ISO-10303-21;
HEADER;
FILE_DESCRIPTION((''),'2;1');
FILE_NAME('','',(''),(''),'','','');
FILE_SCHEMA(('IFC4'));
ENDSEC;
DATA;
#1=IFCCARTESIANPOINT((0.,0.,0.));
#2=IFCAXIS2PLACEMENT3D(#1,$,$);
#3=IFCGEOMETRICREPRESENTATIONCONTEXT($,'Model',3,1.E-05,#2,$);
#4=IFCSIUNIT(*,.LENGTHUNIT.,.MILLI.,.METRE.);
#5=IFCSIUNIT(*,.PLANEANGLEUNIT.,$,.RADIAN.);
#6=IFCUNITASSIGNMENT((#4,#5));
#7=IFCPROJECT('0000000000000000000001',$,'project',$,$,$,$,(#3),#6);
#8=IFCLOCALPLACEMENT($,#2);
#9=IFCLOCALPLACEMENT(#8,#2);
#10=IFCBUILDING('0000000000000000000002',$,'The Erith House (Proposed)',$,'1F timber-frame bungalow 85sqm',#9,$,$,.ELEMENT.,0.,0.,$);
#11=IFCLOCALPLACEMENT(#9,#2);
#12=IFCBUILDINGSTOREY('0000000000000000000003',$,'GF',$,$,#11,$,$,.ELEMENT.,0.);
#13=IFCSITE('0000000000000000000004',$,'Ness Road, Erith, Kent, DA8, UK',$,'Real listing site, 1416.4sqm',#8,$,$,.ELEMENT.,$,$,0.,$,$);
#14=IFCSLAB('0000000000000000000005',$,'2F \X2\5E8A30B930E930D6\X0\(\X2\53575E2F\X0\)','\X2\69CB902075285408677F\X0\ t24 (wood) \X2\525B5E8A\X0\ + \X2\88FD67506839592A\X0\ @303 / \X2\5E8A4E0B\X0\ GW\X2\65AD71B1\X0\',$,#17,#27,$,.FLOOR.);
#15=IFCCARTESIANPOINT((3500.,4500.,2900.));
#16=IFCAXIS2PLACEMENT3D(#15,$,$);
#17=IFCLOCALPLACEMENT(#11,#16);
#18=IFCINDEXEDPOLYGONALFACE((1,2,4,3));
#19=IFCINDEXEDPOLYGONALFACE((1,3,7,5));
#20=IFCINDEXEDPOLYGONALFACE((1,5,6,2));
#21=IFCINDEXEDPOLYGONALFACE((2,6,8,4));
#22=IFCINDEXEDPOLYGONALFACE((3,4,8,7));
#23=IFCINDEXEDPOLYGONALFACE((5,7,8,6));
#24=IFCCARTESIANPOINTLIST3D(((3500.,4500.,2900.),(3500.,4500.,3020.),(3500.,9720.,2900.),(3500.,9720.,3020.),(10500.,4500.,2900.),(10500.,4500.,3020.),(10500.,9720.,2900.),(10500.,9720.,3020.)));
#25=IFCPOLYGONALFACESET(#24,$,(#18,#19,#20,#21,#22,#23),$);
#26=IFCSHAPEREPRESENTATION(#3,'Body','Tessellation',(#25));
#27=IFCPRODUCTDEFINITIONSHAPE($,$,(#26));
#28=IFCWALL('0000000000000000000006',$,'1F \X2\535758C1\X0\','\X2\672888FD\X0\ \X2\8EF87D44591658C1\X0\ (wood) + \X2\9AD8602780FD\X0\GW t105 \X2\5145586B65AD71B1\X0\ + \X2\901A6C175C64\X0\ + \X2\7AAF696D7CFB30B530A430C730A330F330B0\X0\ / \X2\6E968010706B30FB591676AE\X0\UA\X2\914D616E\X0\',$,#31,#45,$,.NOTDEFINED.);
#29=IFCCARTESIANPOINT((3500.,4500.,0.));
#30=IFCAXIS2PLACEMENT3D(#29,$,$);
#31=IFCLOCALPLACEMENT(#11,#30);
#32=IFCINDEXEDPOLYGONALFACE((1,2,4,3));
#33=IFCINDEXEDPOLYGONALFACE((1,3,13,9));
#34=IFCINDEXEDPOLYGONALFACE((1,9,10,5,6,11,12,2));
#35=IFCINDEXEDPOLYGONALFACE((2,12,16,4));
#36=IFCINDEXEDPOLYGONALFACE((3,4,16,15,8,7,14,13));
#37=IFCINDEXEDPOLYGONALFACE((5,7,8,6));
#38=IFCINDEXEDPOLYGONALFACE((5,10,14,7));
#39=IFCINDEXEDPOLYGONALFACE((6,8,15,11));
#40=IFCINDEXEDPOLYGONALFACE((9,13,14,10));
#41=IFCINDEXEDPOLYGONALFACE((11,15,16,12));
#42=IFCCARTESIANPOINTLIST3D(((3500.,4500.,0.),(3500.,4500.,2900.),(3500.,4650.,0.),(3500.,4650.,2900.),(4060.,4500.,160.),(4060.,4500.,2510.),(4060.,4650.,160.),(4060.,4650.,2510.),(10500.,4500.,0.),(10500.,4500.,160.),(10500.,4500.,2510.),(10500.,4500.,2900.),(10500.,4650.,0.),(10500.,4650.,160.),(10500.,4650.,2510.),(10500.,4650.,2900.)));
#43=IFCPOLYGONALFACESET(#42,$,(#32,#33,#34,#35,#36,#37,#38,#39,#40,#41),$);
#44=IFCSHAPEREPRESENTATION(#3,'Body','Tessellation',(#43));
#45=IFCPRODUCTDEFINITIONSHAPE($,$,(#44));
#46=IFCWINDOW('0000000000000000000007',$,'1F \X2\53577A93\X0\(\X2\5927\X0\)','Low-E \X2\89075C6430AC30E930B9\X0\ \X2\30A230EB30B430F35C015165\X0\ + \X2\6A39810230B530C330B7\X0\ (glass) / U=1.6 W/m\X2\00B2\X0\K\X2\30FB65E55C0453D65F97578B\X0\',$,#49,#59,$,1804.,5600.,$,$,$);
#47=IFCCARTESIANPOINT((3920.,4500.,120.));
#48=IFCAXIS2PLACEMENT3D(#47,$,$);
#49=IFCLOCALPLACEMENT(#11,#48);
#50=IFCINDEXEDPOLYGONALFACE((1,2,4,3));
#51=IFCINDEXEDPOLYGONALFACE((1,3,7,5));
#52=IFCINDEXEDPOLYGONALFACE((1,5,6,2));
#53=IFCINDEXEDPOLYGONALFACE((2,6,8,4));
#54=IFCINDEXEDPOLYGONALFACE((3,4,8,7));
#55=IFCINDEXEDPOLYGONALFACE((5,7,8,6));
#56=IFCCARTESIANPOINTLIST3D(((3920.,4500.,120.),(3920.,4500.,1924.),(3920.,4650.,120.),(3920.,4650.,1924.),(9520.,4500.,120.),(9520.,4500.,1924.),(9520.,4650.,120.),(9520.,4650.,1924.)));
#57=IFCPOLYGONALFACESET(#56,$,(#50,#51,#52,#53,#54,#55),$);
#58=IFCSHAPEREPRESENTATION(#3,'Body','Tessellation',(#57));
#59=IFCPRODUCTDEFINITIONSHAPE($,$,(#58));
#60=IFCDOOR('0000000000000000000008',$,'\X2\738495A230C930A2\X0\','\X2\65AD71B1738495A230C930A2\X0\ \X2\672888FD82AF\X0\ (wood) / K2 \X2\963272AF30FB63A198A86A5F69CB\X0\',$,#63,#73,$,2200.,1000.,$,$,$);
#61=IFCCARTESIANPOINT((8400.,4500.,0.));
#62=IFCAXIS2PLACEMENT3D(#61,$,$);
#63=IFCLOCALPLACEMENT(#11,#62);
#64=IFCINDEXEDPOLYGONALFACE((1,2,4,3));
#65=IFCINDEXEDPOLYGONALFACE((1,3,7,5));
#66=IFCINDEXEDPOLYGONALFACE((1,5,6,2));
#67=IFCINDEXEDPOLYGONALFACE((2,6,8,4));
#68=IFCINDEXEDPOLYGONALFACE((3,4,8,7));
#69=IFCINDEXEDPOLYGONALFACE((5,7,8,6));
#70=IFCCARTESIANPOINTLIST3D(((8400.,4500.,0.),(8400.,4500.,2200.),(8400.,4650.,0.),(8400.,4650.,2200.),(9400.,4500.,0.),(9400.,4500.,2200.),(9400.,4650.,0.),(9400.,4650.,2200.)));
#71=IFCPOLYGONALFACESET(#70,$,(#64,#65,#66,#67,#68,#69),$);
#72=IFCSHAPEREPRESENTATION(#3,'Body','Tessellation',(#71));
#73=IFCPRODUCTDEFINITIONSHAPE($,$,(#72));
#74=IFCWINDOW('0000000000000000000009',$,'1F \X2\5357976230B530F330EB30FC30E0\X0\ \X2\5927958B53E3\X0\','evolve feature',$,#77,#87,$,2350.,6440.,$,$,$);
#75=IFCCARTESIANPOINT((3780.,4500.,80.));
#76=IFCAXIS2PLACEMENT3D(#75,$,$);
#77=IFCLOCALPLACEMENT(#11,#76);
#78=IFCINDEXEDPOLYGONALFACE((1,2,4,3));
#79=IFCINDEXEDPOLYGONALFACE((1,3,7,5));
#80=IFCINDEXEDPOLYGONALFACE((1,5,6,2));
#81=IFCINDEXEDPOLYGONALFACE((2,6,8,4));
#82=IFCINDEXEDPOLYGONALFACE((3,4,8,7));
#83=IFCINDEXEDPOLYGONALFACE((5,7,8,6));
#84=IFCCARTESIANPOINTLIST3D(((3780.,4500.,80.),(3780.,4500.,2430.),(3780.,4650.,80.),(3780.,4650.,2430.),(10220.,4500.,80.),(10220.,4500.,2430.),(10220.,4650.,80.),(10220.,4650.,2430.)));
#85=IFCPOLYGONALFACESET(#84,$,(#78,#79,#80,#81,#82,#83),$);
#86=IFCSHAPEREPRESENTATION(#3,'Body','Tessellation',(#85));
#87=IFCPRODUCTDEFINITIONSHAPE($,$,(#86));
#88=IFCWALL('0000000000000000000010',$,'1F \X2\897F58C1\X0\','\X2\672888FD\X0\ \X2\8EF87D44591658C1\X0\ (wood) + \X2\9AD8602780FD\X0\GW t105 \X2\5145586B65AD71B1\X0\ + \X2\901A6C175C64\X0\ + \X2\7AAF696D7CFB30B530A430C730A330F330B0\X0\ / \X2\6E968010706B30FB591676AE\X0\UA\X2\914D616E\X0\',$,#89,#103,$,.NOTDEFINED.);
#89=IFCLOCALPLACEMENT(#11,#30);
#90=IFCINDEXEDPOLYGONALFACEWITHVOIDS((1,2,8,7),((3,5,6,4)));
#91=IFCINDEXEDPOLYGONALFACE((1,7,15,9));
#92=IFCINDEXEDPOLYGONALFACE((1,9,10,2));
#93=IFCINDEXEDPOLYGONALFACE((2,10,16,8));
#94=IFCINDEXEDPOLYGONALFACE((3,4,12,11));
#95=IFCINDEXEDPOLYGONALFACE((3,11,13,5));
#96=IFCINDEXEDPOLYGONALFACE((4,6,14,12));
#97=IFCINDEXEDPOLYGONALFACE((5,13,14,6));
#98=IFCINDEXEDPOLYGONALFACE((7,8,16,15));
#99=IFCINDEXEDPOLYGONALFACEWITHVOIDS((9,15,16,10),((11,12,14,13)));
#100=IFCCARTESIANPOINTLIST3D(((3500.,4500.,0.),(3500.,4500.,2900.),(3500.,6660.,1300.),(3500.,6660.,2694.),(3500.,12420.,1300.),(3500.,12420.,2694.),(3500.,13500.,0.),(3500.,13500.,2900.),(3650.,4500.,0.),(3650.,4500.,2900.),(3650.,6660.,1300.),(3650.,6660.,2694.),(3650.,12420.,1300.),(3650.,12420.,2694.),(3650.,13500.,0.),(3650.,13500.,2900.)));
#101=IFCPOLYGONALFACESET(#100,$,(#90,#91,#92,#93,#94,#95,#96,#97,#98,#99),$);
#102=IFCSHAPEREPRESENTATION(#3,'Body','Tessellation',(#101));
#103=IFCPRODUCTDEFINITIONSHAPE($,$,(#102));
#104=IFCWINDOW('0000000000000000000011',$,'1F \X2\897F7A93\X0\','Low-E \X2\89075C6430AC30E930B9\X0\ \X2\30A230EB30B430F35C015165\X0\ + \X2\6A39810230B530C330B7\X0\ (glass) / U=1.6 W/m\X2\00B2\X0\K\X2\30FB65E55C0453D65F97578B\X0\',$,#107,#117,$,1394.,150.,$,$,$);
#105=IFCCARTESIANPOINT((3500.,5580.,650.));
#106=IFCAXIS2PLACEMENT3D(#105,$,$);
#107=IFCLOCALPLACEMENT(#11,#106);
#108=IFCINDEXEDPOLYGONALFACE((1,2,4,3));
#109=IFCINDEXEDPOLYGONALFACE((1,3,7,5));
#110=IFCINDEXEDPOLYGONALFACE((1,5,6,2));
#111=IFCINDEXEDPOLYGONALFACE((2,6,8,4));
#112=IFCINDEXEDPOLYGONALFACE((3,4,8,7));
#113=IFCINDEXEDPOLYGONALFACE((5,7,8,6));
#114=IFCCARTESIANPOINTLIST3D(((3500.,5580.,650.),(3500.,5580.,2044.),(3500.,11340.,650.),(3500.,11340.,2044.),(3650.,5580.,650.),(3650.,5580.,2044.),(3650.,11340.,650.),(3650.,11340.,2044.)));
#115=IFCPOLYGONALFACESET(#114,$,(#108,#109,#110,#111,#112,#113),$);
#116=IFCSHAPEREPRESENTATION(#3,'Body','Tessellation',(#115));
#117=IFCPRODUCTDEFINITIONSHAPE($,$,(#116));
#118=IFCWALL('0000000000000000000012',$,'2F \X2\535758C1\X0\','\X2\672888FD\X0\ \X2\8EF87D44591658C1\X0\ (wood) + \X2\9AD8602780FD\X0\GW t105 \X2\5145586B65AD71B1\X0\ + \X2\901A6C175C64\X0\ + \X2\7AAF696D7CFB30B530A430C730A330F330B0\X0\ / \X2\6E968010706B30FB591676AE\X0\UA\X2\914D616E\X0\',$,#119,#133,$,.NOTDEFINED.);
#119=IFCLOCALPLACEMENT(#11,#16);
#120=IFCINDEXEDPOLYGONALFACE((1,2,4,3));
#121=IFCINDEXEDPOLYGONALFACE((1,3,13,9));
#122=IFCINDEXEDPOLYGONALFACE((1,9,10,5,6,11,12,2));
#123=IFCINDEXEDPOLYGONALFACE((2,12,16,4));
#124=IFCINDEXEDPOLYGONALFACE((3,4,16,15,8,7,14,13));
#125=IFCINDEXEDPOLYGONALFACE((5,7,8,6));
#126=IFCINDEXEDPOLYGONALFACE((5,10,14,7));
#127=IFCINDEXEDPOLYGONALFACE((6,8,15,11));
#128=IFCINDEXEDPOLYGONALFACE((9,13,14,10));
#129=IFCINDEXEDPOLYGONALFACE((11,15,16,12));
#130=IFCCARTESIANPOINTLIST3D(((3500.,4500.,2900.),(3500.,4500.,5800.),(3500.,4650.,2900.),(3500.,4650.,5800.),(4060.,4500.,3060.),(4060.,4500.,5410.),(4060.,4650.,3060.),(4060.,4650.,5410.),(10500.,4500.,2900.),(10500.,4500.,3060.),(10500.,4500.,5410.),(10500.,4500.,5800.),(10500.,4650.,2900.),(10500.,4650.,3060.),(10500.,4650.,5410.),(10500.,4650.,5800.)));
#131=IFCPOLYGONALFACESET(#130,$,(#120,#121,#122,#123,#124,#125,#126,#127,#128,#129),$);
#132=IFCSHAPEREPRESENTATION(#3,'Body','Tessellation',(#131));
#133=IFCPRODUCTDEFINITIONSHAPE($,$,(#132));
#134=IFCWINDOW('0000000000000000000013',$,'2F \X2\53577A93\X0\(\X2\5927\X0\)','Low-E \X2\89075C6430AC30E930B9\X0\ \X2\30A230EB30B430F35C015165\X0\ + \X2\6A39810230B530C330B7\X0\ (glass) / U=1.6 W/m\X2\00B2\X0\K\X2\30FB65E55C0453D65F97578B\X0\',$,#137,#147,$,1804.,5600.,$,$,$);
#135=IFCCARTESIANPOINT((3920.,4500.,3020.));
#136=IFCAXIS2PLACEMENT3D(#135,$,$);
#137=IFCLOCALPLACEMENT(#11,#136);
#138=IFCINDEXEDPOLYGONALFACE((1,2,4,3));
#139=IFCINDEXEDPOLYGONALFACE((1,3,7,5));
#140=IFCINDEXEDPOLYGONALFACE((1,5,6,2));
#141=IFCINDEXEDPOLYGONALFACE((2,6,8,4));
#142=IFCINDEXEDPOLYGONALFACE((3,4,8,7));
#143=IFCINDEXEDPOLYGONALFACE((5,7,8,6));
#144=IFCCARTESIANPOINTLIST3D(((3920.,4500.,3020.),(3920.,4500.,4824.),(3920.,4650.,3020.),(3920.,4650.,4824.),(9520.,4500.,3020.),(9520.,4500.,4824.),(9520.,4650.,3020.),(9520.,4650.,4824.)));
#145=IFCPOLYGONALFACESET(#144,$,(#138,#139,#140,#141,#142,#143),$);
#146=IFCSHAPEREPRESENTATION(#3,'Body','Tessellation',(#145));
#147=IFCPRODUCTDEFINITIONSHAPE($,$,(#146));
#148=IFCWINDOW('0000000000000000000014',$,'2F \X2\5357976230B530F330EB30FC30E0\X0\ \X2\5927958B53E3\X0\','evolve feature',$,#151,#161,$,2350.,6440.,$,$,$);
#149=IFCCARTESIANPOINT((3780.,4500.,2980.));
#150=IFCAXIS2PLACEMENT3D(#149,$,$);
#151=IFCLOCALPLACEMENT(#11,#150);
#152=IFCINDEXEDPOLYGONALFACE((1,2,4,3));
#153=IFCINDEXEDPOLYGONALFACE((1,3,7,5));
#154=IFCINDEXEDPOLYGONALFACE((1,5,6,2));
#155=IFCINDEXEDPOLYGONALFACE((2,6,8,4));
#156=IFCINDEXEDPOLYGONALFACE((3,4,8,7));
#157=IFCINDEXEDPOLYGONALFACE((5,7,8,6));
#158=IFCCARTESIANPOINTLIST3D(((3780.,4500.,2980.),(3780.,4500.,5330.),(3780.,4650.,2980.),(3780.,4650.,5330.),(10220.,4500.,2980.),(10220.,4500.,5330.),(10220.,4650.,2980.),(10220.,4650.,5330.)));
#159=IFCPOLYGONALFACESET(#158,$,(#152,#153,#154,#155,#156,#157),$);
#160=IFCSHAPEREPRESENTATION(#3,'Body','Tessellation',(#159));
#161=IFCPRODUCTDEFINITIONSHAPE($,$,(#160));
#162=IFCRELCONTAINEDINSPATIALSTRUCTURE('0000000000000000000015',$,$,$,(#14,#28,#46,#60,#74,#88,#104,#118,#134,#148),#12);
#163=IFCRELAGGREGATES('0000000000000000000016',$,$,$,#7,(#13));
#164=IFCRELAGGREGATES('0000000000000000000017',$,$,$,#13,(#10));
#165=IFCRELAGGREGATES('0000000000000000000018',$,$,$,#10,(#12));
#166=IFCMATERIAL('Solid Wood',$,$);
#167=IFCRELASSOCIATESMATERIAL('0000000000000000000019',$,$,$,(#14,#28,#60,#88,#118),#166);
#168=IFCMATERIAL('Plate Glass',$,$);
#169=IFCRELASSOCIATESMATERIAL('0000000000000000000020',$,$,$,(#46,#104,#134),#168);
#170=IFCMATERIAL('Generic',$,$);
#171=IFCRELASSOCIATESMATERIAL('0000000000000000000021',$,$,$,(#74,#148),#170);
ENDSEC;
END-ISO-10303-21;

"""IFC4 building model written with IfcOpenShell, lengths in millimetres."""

from ifc_helpers import new_model, si_unit, frame, frame_2d, origin, place, context, project, spatial, rectangle, extrude, material, element, fill, save


model = new_model("IFC4")

# Units and contexts
model_context = context("Model", 3, precision=1e-05, world=origin())
ifc_project = project(units=[si_unit("LENGTHUNIT", "METRE", prefix="MILLI"), si_unit("PLANEANGLEUNIT", "RADIAN")], contexts=[model_context])

# Site, building, storey
site_placement = place(None, origin())
site = spatial("IfcSite", under=ifc_project, at=site_placement, Name="Ness Road, Erith, Kent, DA8, UK", ObjectType="Real listing site, 1416.4sqm", CompositionType="ELEMENT", RefElevation=0.0)
building_placement = place(site_placement, origin())
building = spatial("IfcBuilding", under=site, at=building_placement, Name="The Erith House (Proposed)", ObjectType="1F timber-frame bungalow 85sqm", CompositionType="ELEMENT", ElevationOfRefHeight=0.0, ElevationOfTerrain=0.0)
storey_placement = place(building_placement, origin())
storey = spatial("IfcBuildingStorey", under=building, at=storey_placement, Name="GF", CompositionType="ELEMENT", Elevation=0.0)

# Slab
ifc_material_1 = material(Name="Solid Wood")
slab_1_placement = place(storey_placement, frame((3500.0, 4500.0, 2900.0)))
element("IfcSlab", 1, at=slab_1_placement, inside=storey, material=ifc_material_1, Name="2F 床スラブ(南帯)", Description="構造用合板 t24 (wood) 剛床 + 製材根太 @303 / 床下 GW断熱", PredefinedType="FLOOR", context=model_context, shape_type="SweptSolid", body=[
    extrude(rectangle(XDim=7000.0, YDim=5220.0, at=frame_2d((3500.0, 2610.0))), frame((3500.0, 4500.0, 2900.0)), (0.0, 0.0, 1.0), 120.0),
])
ifc_material_2 = material(Name="Generic")

# Wall, openings, windows, door
wall_1_placement = place(storey_placement, frame((3500.0, 4500.0, 0.0)))
wall_1 = element("IfcWall", 2, at=wall_1_placement, inside=storey, material=ifc_material_1, Name="1F 南壁", Description="木製 軸組外壁 (wood) + 高性能GW t105 充填断熱 + 通気層 + 窯業系サイディング / 準耐火・外皮UA配慮", PredefinedType="NOTDEFINED", context=model_context, shape_type="SweptSolid", body=[
    extrude(rectangle(XDim=7000.0, YDim=150.0, at=frame_2d((3500.0, 75.0))), frame((3500.0, 4500.0, 0.0)), (0.0, 0.0, 1.0), 2900.0),
])
opening_1_placement = place(storey_placement, frame((3920.0, 4500.0, 120.0)))
opening_1 = element("IfcOpeningElement", 3, at=opening_1_placement, cuts=wall_1, PredefinedType="NOTDEFINED", context=model_context, shape_type="SweptSolid", body=[
    extrude(rectangle(XDim=5600.0, YDim=150.0, at=frame_2d((2800.0, 75.0))), frame((3920.0, 4500.0, 120.0)), (0.0, 0.0, 1.0), 1804.0),
])
opening_2_placement = place(storey_placement, frame((8400.0, 4500.0, 0.0)))
opening_2 = element("IfcOpeningElement", 4, at=opening_2_placement, cuts=wall_1, PredefinedType="NOTDEFINED", context=model_context, shape_type="SweptSolid", body=[
    extrude(rectangle(XDim=1000.0, YDim=150.0, at=frame_2d((500.0, 75.0))), frame((8400.0, 4500.0, 0.0)), (0.0, 0.0, 1.0), 2200.0),
])
opening_3_placement = place(storey_placement, frame((3780.0, 4500.0, 80.0)))
opening_3 = element("IfcOpeningElement", 5, at=opening_3_placement, cuts=wall_1, PredefinedType="NOTDEFINED", context=model_context, shape_type="SweptSolid", body=[
    extrude(rectangle(XDim=6440.0, YDim=150.0, at=frame_2d((3220.0, 75.0))), frame((3780.0, 4500.0, 80.0)), (0.0, 0.0, 1.0), 2350.0),
])
ifc_material_3 = material(Name="Plate Glass")
window_1_placement = place(storey_placement, frame((3920.0, 4500.0, 120.0)))
window_1 = element("IfcWindow", 6, at=window_1_placement, inside=storey, material=ifc_material_3, Name="1F 南窓(大)", Description="Low-E 複層ガラス アルゴン封入 + 樹脂サッシ (glass) / U=1.6 W/m²K・日射取得型", OverallHeight=1804.0, OverallWidth=5600.0, context=model_context, shape_type="SweptSolid", body=[
    extrude(rectangle(XDim=5600.0, YDim=150.0, at=frame_2d((2800.0, 75.0))), frame((3920.0, 4500.0, 120.0)), (0.0, 0.0, 1.0), 1804.0),
])
fill(opening_1, window_1)
door_placement = place(storey_placement, frame((8400.0, 4500.0, 0.0)))
door = element("IfcDoor", 7, at=door_placement, inside=storey, material=ifc_material_1, Name="玄関ドア", Description="断熱玄関ドア 木製芯 (wood) / K2 防犯・採風機構", OverallHeight=2200.0, OverallWidth=1000.0, context=model_context, shape_type="SweptSolid", body=[
    extrude(rectangle(XDim=1000.0, YDim=150.0, at=frame_2d((500.0, 75.0))), frame((8400.0, 4500.0, 0.0)), (0.0, 0.0, 1.0), 2200.0),
])
fill(opening_2, door)
window_2_placement = place(storey_placement, frame((3780.0, 4500.0, 80.0)))
window_2 = element("IfcWindow", 8, at=window_2_placement, inside=storey, material=ifc_material_2, Name="1F 南面サンルーム 大開口", Description="evolve feature", OverallHeight=2350.0, OverallWidth=6440.0, context=model_context, shape_type="SweptSolid", body=[
    extrude(rectangle(XDim=6440.0, YDim=150.0, at=frame_2d((3220.0, 75.0))), frame((3780.0, 4500.0, 80.0)), (0.0, 0.0, 1.0), 2350.0),
])
fill(opening_3, window_2)

# Wall, opening, window
wall_2_placement = place(storey_placement, frame((3500.0, 4500.0, 0.0)))
wall_2 = element("IfcWall", 9, at=wall_2_placement, inside=storey, material=ifc_material_1, Name="1F 西壁", Description="木製 軸組外壁 (wood) + 高性能GW t105 充填断熱 + 通気層 + 窯業系サイディング / 準耐火・外皮UA配慮", PredefinedType="NOTDEFINED", context=model_context, shape_type="SweptSolid", body=[
    extrude(rectangle(XDim=150.0, YDim=9000.0, at=frame_2d((75.0, 4500.0))), frame((3500.0, 4500.0, 0.0)), (0.0, 0.0, 1.0), 2900.0),
])
opening_4_placement = place(storey_placement, frame((3500.0, 5580.0, 650.0)))
opening_4 = element("IfcOpeningElement", 10, at=opening_4_placement, cuts=wall_2, PredefinedType="NOTDEFINED", context=model_context, shape_type="SweptSolid", body=[
    extrude(rectangle(XDim=150.0, YDim=5760.0, at=frame_2d((75.0, 2880.0))), frame((3500.0, 5580.0, 650.0)), (0.0, 0.0, 1.0), 1394.0),
])
window_3_placement = place(storey_placement, frame((3500.0, 5580.0, 650.0)))
window_3 = element("IfcWindow", 11, at=window_3_placement, inside=storey, material=ifc_material_3, Name="1F 西窓", Description="Low-E 複層ガラス アルゴン封入 + 樹脂サッシ (glass) / U=1.6 W/m²K・日射取得型", OverallHeight=1394.0, OverallWidth=150.0, context=model_context, shape_type="SweptSolid", body=[
    extrude(rectangle(XDim=150.0, YDim=5760.0, at=frame_2d((75.0, 2880.0))), frame((3500.0, 5580.0, 650.0)), (0.0, 0.0, 1.0), 1394.0),
])
fill(opening_4, window_3)

# Wall, openings, windows
wall_3_placement = place(storey_placement, frame((3500.0, 4500.0, 2900.0)))
wall_3 = element("IfcWall", 12, at=wall_3_placement, inside=storey, material=ifc_material_1, Name="2F 南壁", Description="木製 軸組外壁 (wood) + 高性能GW t105 充填断熱 + 通気層 + 窯業系サイディング / 準耐火・外皮UA配慮", PredefinedType="NOTDEFINED", context=model_context, shape_type="SweptSolid", body=[
    extrude(rectangle(XDim=7000.0, YDim=150.0, at=frame_2d((3500.0, 75.0))), frame((3500.0, 4500.0, 2900.0)), (0.0, 0.0, 1.0), 2900.0),
])
opening_5_placement = place(storey_placement, frame((3920.0, 4500.0, 3020.0)))
opening_5 = element("IfcOpeningElement", 13, at=opening_5_placement, cuts=wall_3, PredefinedType="NOTDEFINED", context=model_context, shape_type="SweptSolid", body=[
    extrude(rectangle(XDim=5600.0, YDim=150.0, at=frame_2d((2800.0, 75.0))), frame((3920.0, 4500.0, 3020.0)), (0.0, 0.0, 1.0), 1804.0),
])
opening_6_placement = place(storey_placement, frame((3780.0, 4500.0, 2980.0)))
opening_6 = element("IfcOpeningElement", 14, at=opening_6_placement, cuts=wall_3, PredefinedType="NOTDEFINED", context=model_context, shape_type="SweptSolid", body=[
    extrude(rectangle(XDim=6440.0, YDim=150.0, at=frame_2d((3220.0, 75.0))), frame((3780.0, 4500.0, 2980.0)), (0.0, 0.0, 1.0), 2350.0),
])
window_4_placement = place(storey_placement, frame((3920.0, 4500.0, 3020.0)))
window_4 = element("IfcWindow", 15, at=window_4_placement, inside=storey, material=ifc_material_3, Name="2F 南窓(大)", Description="Low-E 複層ガラス アルゴン封入 + 樹脂サッシ (glass) / U=1.6 W/m²K・日射取得型", OverallHeight=1804.0, OverallWidth=5600.0, context=model_context, shape_type="SweptSolid", body=[
    extrude(rectangle(XDim=5600.0, YDim=150.0, at=frame_2d((2800.0, 75.0))), frame((3920.0, 4500.0, 3020.0)), (0.0, 0.0, 1.0), 1804.0),
])
fill(opening_5, window_4)
window_5_placement = place(storey_placement, frame((3780.0, 4500.0, 2980.0)))
window_5 = element("IfcWindow", 16, at=window_5_placement, inside=storey, material=ifc_material_2, Name="2F 南面サンルーム 大開口", Description="evolve feature", OverallHeight=2350.0, OverallWidth=6440.0, context=model_context, shape_type="SweptSolid", body=[
    extrude(rectangle(XDim=6440.0, YDim=150.0, at=frame_2d((3220.0, 75.0))), frame((3780.0, 4500.0, 2980.0)), (0.0, 0.0, 1.0), 2350.0),
])
fill(opening_6, window_5)

save(model, "model.ifc")
